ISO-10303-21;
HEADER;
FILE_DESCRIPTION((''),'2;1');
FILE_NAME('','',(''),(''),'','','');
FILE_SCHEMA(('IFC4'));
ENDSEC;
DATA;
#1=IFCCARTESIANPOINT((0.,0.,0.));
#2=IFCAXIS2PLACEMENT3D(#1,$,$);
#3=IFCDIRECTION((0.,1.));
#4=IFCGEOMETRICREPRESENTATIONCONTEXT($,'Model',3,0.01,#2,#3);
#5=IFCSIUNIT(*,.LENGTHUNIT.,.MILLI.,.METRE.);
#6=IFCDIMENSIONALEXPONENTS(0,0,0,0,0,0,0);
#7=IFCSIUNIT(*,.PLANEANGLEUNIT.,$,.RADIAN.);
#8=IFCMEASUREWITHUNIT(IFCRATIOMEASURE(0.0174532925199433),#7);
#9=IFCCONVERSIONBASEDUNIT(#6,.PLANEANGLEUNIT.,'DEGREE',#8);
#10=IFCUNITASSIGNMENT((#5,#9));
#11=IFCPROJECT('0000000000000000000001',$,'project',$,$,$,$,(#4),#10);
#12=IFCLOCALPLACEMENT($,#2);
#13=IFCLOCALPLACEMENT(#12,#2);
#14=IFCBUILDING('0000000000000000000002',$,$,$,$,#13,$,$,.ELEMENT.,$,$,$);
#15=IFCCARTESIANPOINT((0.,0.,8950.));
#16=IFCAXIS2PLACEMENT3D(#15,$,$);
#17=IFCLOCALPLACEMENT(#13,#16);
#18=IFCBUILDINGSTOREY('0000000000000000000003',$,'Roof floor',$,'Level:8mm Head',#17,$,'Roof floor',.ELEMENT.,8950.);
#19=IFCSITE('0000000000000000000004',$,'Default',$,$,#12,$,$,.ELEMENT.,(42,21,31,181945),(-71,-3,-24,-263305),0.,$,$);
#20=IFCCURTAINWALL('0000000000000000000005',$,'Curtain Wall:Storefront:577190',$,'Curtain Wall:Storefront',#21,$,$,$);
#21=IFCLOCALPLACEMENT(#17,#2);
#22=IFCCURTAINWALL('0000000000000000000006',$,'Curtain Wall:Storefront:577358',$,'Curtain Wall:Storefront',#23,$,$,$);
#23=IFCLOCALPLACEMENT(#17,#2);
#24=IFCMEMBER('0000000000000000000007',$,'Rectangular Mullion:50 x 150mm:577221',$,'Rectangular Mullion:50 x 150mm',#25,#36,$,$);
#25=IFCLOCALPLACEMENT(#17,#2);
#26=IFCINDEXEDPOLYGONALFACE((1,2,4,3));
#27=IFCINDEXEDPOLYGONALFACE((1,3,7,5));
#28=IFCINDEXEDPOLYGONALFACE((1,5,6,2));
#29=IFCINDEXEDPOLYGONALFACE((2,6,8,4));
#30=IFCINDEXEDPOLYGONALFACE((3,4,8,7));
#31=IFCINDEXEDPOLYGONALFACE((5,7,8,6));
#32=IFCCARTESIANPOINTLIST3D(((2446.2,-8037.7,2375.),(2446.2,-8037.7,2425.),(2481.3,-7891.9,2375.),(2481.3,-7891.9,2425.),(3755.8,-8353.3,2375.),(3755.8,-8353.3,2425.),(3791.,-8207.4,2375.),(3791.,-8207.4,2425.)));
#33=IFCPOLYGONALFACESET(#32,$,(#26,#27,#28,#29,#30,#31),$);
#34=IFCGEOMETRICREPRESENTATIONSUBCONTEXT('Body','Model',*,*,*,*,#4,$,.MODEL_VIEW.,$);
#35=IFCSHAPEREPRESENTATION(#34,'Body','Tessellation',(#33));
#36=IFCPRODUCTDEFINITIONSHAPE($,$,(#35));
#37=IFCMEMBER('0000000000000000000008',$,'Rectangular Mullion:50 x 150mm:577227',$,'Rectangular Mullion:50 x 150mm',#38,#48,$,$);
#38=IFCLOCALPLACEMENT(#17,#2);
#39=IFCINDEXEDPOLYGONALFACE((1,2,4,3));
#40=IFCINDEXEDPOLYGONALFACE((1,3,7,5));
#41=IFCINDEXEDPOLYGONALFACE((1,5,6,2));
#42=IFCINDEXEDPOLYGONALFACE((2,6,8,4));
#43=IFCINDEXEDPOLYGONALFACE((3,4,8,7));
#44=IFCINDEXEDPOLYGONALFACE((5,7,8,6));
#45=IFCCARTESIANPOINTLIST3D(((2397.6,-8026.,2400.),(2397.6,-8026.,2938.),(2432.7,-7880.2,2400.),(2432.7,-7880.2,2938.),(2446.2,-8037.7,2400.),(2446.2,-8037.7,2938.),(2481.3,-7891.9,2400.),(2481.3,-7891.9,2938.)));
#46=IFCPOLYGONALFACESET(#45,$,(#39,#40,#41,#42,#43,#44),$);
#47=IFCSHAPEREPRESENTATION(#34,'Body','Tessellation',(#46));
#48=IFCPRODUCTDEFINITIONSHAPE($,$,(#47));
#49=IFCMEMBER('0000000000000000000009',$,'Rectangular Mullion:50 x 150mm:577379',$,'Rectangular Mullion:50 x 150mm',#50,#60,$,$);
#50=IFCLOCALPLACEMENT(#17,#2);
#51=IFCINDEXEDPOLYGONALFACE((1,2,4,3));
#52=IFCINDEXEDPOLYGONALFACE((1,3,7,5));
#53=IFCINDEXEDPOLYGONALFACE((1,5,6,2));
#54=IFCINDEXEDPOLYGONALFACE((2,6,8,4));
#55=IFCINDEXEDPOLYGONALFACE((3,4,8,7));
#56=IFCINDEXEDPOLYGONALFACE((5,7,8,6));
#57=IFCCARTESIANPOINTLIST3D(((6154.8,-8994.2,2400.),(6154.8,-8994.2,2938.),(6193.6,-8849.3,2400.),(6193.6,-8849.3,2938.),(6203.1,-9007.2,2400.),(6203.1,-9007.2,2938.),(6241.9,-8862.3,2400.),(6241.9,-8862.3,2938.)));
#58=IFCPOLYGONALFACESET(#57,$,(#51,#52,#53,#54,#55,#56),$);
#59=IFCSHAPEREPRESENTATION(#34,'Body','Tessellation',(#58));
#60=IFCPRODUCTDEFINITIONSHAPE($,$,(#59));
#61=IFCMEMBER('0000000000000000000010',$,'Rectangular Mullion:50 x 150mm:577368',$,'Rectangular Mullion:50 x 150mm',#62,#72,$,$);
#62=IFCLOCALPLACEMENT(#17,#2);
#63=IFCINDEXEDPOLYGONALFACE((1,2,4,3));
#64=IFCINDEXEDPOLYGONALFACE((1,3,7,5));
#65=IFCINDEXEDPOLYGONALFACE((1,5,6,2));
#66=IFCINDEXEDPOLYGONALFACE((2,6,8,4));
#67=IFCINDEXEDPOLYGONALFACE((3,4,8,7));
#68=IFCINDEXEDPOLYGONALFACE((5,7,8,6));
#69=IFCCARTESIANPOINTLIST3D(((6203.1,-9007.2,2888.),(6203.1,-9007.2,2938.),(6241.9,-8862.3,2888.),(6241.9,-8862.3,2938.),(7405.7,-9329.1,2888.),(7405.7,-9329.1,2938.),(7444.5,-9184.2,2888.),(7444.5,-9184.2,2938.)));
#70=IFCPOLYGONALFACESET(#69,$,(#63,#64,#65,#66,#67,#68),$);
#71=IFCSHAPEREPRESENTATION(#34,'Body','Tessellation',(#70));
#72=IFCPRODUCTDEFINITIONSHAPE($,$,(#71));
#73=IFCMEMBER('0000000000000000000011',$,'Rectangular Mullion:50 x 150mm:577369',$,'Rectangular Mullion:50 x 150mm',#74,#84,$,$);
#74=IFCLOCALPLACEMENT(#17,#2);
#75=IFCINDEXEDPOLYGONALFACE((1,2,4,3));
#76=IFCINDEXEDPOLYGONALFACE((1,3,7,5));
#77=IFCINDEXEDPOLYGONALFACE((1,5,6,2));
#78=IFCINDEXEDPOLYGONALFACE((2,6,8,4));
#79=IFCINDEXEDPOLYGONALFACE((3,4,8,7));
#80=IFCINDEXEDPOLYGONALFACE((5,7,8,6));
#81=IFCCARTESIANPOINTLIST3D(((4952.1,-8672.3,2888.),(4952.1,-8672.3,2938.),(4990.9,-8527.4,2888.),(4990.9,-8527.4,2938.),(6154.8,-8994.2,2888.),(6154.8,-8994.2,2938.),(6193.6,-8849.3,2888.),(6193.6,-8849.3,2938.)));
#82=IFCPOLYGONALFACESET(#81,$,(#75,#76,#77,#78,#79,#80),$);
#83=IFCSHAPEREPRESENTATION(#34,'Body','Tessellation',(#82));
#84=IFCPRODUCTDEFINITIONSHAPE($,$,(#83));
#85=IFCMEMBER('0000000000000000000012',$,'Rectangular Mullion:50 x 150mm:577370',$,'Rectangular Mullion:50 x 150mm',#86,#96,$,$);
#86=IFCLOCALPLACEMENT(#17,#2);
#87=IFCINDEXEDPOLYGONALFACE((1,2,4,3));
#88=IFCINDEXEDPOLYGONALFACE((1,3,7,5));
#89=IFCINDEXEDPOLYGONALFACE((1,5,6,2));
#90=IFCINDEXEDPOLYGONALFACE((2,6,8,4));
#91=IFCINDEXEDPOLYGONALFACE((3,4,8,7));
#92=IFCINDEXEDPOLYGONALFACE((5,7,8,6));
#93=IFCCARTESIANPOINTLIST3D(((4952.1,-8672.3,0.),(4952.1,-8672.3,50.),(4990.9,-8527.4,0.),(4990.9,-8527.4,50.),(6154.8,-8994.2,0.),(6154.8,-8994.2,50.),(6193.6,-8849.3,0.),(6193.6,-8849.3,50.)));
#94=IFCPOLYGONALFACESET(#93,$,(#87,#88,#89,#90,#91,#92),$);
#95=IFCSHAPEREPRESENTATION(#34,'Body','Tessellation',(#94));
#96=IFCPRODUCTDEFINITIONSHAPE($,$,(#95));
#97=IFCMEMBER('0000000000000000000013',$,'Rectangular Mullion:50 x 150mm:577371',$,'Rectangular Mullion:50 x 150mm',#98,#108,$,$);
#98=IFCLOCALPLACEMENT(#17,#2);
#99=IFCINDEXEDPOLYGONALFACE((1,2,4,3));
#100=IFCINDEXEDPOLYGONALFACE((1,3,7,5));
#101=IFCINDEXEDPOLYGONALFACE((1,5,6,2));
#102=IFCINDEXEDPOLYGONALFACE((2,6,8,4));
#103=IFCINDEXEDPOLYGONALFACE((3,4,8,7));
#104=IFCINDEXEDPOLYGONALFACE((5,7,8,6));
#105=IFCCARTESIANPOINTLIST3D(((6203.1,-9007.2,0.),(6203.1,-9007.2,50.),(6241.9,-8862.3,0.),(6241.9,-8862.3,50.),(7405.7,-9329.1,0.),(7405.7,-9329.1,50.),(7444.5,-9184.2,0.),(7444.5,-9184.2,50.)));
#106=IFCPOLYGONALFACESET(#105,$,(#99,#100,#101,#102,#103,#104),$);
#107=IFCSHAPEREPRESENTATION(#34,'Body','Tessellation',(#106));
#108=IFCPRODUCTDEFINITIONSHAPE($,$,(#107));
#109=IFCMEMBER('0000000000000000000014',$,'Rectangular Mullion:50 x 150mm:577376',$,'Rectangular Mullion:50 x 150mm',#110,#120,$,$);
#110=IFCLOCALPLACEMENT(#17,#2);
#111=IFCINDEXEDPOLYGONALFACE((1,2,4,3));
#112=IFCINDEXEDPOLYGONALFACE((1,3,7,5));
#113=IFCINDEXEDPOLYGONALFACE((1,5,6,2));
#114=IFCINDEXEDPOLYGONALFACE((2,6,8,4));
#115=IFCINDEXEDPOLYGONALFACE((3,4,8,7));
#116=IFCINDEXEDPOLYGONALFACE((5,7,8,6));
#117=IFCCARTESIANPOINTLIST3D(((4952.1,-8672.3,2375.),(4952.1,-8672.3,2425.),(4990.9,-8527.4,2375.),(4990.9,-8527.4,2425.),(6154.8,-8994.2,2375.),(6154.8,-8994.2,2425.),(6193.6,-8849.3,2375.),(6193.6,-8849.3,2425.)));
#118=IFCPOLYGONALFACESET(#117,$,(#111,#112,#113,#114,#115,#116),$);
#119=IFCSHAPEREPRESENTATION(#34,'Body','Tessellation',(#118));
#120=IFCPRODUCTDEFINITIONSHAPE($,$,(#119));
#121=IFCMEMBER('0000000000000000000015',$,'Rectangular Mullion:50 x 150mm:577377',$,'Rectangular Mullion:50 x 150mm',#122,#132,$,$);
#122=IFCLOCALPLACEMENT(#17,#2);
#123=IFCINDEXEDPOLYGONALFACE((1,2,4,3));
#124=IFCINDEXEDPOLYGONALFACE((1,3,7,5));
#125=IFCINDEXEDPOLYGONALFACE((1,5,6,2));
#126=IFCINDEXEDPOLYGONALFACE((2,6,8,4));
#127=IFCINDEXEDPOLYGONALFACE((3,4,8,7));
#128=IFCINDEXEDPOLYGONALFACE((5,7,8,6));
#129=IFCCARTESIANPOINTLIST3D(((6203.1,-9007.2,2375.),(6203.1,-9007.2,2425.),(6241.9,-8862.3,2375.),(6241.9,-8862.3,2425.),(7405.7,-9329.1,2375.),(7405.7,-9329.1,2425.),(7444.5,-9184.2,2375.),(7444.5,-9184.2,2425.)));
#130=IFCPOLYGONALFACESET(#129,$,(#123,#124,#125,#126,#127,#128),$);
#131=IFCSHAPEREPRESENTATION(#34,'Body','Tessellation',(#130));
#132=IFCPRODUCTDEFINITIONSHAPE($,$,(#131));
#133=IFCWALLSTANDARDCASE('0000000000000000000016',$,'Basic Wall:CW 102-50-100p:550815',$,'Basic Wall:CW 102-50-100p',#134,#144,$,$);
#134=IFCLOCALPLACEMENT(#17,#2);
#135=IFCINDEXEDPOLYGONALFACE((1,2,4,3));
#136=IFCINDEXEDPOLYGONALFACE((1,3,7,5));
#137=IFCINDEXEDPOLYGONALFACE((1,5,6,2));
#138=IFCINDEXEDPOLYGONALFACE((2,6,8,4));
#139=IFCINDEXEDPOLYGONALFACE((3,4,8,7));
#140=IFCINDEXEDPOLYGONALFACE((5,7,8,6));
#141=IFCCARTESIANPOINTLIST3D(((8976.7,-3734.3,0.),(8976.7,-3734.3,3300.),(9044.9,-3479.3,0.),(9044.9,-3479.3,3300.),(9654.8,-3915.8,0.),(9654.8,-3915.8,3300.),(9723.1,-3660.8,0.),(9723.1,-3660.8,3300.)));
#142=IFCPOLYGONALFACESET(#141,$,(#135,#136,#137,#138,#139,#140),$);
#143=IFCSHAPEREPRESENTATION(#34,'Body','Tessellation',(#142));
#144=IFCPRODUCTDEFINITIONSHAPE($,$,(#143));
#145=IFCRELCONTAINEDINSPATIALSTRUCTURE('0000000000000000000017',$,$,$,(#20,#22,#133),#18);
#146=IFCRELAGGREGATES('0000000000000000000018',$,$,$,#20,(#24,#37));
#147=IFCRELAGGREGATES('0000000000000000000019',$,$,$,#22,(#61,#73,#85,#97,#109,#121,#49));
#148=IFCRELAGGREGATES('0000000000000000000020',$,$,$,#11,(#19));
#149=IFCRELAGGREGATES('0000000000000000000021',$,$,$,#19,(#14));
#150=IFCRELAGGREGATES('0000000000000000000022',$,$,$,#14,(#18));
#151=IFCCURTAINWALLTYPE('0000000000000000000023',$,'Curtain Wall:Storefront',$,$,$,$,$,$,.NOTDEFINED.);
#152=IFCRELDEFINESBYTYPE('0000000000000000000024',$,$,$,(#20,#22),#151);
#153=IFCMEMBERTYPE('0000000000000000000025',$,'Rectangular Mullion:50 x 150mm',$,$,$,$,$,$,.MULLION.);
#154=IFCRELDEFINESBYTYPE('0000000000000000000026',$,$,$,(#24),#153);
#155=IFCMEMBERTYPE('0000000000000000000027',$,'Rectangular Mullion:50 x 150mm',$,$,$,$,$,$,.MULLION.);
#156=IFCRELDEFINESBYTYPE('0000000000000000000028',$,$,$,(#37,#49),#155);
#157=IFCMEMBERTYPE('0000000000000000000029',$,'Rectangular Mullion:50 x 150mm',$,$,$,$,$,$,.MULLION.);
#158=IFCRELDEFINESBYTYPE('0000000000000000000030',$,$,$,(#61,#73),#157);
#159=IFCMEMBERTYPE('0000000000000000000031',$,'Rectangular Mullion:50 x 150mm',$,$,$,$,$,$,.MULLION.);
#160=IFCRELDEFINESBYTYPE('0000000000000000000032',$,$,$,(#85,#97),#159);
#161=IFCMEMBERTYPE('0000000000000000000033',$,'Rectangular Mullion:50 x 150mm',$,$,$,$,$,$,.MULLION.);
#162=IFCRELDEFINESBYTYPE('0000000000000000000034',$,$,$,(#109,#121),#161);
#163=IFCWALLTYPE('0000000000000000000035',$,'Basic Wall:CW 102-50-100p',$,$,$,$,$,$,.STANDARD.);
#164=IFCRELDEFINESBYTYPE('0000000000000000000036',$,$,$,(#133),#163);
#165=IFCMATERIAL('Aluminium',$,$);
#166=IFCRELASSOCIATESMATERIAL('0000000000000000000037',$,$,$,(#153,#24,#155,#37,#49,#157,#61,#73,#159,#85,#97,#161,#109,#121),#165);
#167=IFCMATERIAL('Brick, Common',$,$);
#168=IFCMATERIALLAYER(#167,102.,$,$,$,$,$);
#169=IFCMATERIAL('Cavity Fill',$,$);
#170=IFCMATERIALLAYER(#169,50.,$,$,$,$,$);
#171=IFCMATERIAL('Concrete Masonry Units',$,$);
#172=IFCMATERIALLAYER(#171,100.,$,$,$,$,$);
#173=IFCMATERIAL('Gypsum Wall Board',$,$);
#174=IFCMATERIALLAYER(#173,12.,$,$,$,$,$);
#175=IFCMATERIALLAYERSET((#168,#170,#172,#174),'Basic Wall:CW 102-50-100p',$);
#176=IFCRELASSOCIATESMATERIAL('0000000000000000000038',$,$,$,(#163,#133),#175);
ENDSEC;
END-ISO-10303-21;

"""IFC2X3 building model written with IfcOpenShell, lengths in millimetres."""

from ifc_helpers import new_model, entity, si_unit, converted_unit, direction, frame, frame_2d, origin, origin_2d_with_axis, place, context, subcontext, project, spatial, rectangle, extrude, source, transform, mapped, material, layer, layer_set, layer_usage, type_object, type_shapes, element, aggregate, save


model = new_model("IFC2X3")

# Units and contexts
model_context = context("Model", 3, precision=0.01, world=origin(), true_north=direction((0.0, 1.0)))
body_context = subcontext(model_context, "Body", "Model", "MODEL_VIEW")
ifc_project = project(units=[si_unit("LENGTHUNIT", "METRE", prefix="MILLI"), converted_unit("PLANEANGLEUNIT", "DEGREE", entity("IfcRatioMeasure", 0.0174532925199433), si_unit("PLANEANGLEUNIT", "RADIAN"), dimensions=[0, 0, 0, 0, 0, 0, 0])], contexts=[model_context])

# Site, building, storey
site_placement = place(None, origin())
site = spatial("IfcSite", under=ifc_project, at=site_placement, Name="Default", CompositionType="ELEMENT", RefLatitude=(42, 21, 31, 181945), RefLongitude=(-71, -3, -24, -263305), RefElevation=0.0)
building_placement = place(site_placement, origin())
building = spatial("IfcBuilding", under=site, at=building_placement, CompositionType="ELEMENT")
storey_placement = place(building_placement, frame((0.0, 0.0, 8950.0)))
storey = spatial("IfcBuildingStorey", under=building, at=storey_placement, Name="Roof floor", ObjectType="Level:8mm Head", LongName="Roof floor", CompositionType="ELEMENT", Elevation=8950.0)

# Curtain walls
curtain_wall_type = type_object("IfcCurtainWallType", Name="Curtain Wall:Storefront", PredefinedType="NOTDEFINED")
curtain_wall_1_placement = place(storey_placement, frame((0.0, 0.0, -8950.0)))
curtain_wall_1 = element("IfcCurtainWall", 1, at=curtain_wall_1_placement, inside=storey, type_object=curtain_wall_type, Name="Curtain Wall:Storefront:577190", ObjectType="Curtain Wall:Storefront")
ifc_material_1 = material(Name="Aluminium")
curtain_wall_2_placement = place(storey_placement, frame((0.0, 0.0, -8950.0)))
curtain_wall_2 = element("IfcCurtainWall", 2, at=curtain_wall_2_placement, inside=storey, type_object=curtain_wall_type, Name="Curtain Wall:Storefront:577358", ObjectType="Curtain Wall:Storefront")

# Members
member_type_1 = type_object("IfcMemberType", Name="Rectangular Mullion:50 x 150mm", PredefinedType="MULLION", material=ifc_material_1)
shared_shape_1 = source(origin(), body_context, "Body", "SweptSolid", [
    extrude(rectangle(XDim=150.0, YDim=50.0, at=origin_2d_with_axis()), frame((0.0, 0.0, -1347.1), z_axis=(0.0, 0.0, 1.0), x_axis=(0.0, -1.0, 0.0)), (0.0, 0.0, 1.0), 1347.1),
])
type_shapes(member_type_1, [shared_shape_1])
member_1_placement = place(storey_placement, frame((3773.4, -8280.4, 2400.0), z_axis=(0.972184, -0.234217, 0.0), x_axis=(0.0, 0.0, 1.0)))
member_1 = element("IfcMember", 3, at=member_1_placement, type_object=member_type_1, material=ifc_material_1, Name="Rectangular Mullion:50 x 150mm:577221", ObjectType="Rectangular Mullion:50 x 150mm", context=body_context, shape_type="MappedRepresentation", body=[
    mapped(shared_shape_1, transform((0.0, 0.0, 0.0), scale=1.0)),
])
member_type_2 = type_object("IfcMemberType", Name="Rectangular Mullion:50 x 150mm", PredefinedType="MULLION", material=ifc_material_1)
shared_shape_2 = source(origin(), body_context, "Body", "SweptSolid", [
    extrude(rectangle(XDim=150.0, YDim=50.0, at=origin_2d_with_axis()), frame((0.0, 0.0, -538.0), z_axis=(0.0, 0.0, 1.0), x_axis=(0.0, -1.0, 0.0)), (0.0, 0.0, 1.0), 538.0),
])
type_shapes(member_type_2, [shared_shape_2])
member_2_placement = place(storey_placement, frame((2439.4, -7959.0, 2400.0), z_axis=(0.0, 0.0, -1.0), x_axis=(0.972184, -0.234217, 0.0)))
member_2 = element("IfcMember", 4, at=member_2_placement, type_object=member_type_2, material=ifc_material_1, Name="Rectangular Mullion:50 x 150mm:577227", ObjectType="Rectangular Mullion:50 x 150mm", context=body_context, shape_type="MappedRepresentation", body=[
    mapped(shared_shape_2, transform((0.0, 0.0, 0.0), scale=1.0)),
])
member_3_placement = place(storey_placement, frame((6198.3, -8928.2, 2400.0), z_axis=(0.0, 0.0, -1.0), x_axis=(0.965983, -0.258607, 0.0)))
member_3 = element("IfcMember", 5, at=member_3_placement, type_object=member_type_2, material=ifc_material_1, Name="Rectangular Mullion:50 x 150mm:577379", ObjectType="Rectangular Mullion:50 x 150mm", context=body_context, shape_type="MappedRepresentation", body=[
    mapped(shared_shape_2, transform((0.0, 0.0, 0.0), scale=1.0)),
])
member_type_3 = type_object("IfcMemberType", Name="Rectangular Mullion:50 x 150mm", PredefinedType="MULLION", material=ifc_material_1)
shared_shape_3 = source(origin(), body_context, "Body", "SweptSolid", [
    extrude(rectangle(XDim=150.0, YDim=50.0, at=origin_2d_with_axis()), frame((-25.0, 0.0, -1245.0), z_axis=(0.0, 0.0, 1.0), x_axis=(0.0, -1.0, 0.0)), (0.0, 0.0, 1.0), 1245.0),
])
type_shapes(member_type_3, [shared_shape_3])
member_4_placement = place(storey_placement, frame((7425.1, -9256.7, 2938.0), z_axis=(0.965983, -0.258607, 0.0), x_axis=(0.0, 0.0, 1.0)))
member_4 = element("IfcMember", 6, at=member_4_placement, type_object=member_type_3, material=ifc_material_1, Name="Rectangular Mullion:50 x 150mm:577368", ObjectType="Rectangular Mullion:50 x 150mm", context=body_context, shape_type="MappedRepresentation", body=[
    mapped(shared_shape_3, transform((0.0, 0.0, 0.0), scale=1.0)),
])
member_5_placement = place(storey_placement, frame((6174.2, -8921.8, 2938.0), z_axis=(0.965983, -0.258607, 0.0), x_axis=(0.0, 0.0, 1.0)))
member_5 = element("IfcMember", 7, at=member_5_placement, type_object=member_type_3, material=ifc_material_1, Name="Rectangular Mullion:50 x 150mm:577369", ObjectType="Rectangular Mullion:50 x 150mm", context=body_context, shape_type="MappedRepresentation", body=[
    mapped(shared_shape_3, transform((0.0, 0.0, 0.0), scale=1.0)),
])
member_type_4 = type_object("IfcMemberType", Name="Rectangular Mullion:50 x 150mm", PredefinedType="MULLION", material=ifc_material_1)
shared_shape_4 = source(origin(), body_context, "Body", "SweptSolid", [
    extrude(rectangle(XDim=150.0, YDim=50.0, at=origin_2d_with_axis()), frame((-25.0, 0.0, -1245.0), z_axis=(0.0, 0.0, 1.0), x_axis=(0.0, -1.0, 0.0)), (0.0, 0.0, 1.0), 1245.0),
])
type_shapes(member_type_4, [shared_shape_4])
member_6_placement = place(storey_placement, frame((4971.5, -8599.8, 0.0), z_axis=(-0.965983, 0.258607, 0.0), x_axis=(0.0, 0.0, -1.0)))
member_6 = element("IfcMember", 8, at=member_6_placement, type_object=member_type_4, material=ifc_material_1, Name="Rectangular Mullion:50 x 150mm:577370", ObjectType="Rectangular Mullion:50 x 150mm", context=body_context, shape_type="MappedRepresentation", body=[
    mapped(shared_shape_4, transform((0.0, 0.0, 0.0), scale=1.0)),
])
member_7_placement = place(storey_placement, frame((6222.5, -8934.7, 0.0), z_axis=(-0.965983, 0.258607, 0.0), x_axis=(0.0, 0.0, -1.0)))
member_7 = element("IfcMember", 9, at=member_7_placement, type_object=member_type_4, material=ifc_material_1, Name="Rectangular Mullion:50 x 150mm:577371", ObjectType="Rectangular Mullion:50 x 150mm", context=body_context, shape_type="MappedRepresentation", body=[
    mapped(shared_shape_4, transform((0.0, 0.0, 0.0), scale=1.0)),
])
member_type_5 = type_object("IfcMemberType", Name="Rectangular Mullion:50 x 150mm", PredefinedType="MULLION", material=ifc_material_1)
shared_shape_5 = source(origin(), body_context, "Body", "SweptSolid", [
    extrude(rectangle(XDim=150.0, YDim=50.0, at=origin_2d_with_axis()), frame((0.0, 0.0, -1245.0), z_axis=(0.0, 0.0, 1.0), x_axis=(0.0, -1.0, 0.0)), (0.0, 0.0, 1.0), 1245.0),
])
type_shapes(member_type_5, [shared_shape_5])
member_8_placement = place(storey_placement, frame((6174.2, -8921.8, 2400.0), z_axis=(0.965983, -0.258607, 0.0), x_axis=(0.0, 0.0, 1.0)))
member_8 = element("IfcMember", 10, at=member_8_placement, type_object=member_type_5, material=ifc_material_1, Name="Rectangular Mullion:50 x 150mm:577376", ObjectType="Rectangular Mullion:50 x 150mm", context=body_context, shape_type="MappedRepresentation", body=[
    mapped(shared_shape_5, transform((0.0, 0.0, 0.0), scale=1.0)),
])
member_9_placement = place(storey_placement, frame((7425.1, -9256.7, 2400.0), z_axis=(0.965983, -0.258607, 0.0), x_axis=(0.0, 0.0, 1.0)))
member_9 = element("IfcMember", 11, at=member_9_placement, type_object=member_type_5, material=ifc_material_1, Name="Rectangular Mullion:50 x 150mm:577377", ObjectType="Rectangular Mullion:50 x 150mm", context=body_context, shape_type="MappedRepresentation", body=[
    mapped(shared_shape_5, transform((0.0, 0.0, 0.0), scale=1.0)),
])

aggregate(curtain_wall_1, [member_1, member_2])
aggregate(curtain_wall_2, [member_4, member_5, member_6, member_7, member_8, member_9, member_3])

# Wall
ifc_material_2 = material(Name="Brick, Common")
ifc_layer_1 = layer(ifc_material_2, 102.0)
ifc_material_3 = material(Name="Cavity Fill")
ifc_layer_2 = layer(ifc_material_3, 50.0)
ifc_material_4 = material(Name="Concrete Masonry Units")
ifc_layer_3 = layer(ifc_material_4, 100.0)
ifc_material_5 = material(Name="Gypsum Wall Board")
ifc_layer_4 = layer(ifc_material_5, 12.0)
ifc_layer_set = layer_set([ifc_layer_1, ifc_layer_2, ifc_layer_3, ifc_layer_4], Name="Basic Wall:CW 102-50-100p")
ifc_layer_usage_1 = layer_usage(ifc_layer_set, "AXIS2", "NEGATIVE", 132.0)
wall_type = type_object("IfcWallType", Name="Basic Wall:CW 102-50-100p", PredefinedType="STANDARD", material=ifc_layer_set)
wall_1_placement = place(storey_placement, frame((9688.9, -3788.3, 0.0), z_axis=(0.0, 0.0, 1.0), x_axis=(-0.965983, 0.258607, 0.0)))
element("IfcWallStandardCase", 12, at=wall_1_placement, inside=storey, type_object=wall_type, material=ifc_layer_usage_1, Name="Basic Wall:CW 102-50-100p:550815", ObjectType="Basic Wall:CW 102-50-100p", context=body_context, shape_type="SweptSolid", body=[
    extrude(rectangle(XDim=702.0, YDim=264.0, at=frame_2d((351.0, 0.0), x_axis=(-1.0, 0.0))), origin(), (0.0, 0.0, 1.0), 3300.0),
])

save(model, "model.ifc")
